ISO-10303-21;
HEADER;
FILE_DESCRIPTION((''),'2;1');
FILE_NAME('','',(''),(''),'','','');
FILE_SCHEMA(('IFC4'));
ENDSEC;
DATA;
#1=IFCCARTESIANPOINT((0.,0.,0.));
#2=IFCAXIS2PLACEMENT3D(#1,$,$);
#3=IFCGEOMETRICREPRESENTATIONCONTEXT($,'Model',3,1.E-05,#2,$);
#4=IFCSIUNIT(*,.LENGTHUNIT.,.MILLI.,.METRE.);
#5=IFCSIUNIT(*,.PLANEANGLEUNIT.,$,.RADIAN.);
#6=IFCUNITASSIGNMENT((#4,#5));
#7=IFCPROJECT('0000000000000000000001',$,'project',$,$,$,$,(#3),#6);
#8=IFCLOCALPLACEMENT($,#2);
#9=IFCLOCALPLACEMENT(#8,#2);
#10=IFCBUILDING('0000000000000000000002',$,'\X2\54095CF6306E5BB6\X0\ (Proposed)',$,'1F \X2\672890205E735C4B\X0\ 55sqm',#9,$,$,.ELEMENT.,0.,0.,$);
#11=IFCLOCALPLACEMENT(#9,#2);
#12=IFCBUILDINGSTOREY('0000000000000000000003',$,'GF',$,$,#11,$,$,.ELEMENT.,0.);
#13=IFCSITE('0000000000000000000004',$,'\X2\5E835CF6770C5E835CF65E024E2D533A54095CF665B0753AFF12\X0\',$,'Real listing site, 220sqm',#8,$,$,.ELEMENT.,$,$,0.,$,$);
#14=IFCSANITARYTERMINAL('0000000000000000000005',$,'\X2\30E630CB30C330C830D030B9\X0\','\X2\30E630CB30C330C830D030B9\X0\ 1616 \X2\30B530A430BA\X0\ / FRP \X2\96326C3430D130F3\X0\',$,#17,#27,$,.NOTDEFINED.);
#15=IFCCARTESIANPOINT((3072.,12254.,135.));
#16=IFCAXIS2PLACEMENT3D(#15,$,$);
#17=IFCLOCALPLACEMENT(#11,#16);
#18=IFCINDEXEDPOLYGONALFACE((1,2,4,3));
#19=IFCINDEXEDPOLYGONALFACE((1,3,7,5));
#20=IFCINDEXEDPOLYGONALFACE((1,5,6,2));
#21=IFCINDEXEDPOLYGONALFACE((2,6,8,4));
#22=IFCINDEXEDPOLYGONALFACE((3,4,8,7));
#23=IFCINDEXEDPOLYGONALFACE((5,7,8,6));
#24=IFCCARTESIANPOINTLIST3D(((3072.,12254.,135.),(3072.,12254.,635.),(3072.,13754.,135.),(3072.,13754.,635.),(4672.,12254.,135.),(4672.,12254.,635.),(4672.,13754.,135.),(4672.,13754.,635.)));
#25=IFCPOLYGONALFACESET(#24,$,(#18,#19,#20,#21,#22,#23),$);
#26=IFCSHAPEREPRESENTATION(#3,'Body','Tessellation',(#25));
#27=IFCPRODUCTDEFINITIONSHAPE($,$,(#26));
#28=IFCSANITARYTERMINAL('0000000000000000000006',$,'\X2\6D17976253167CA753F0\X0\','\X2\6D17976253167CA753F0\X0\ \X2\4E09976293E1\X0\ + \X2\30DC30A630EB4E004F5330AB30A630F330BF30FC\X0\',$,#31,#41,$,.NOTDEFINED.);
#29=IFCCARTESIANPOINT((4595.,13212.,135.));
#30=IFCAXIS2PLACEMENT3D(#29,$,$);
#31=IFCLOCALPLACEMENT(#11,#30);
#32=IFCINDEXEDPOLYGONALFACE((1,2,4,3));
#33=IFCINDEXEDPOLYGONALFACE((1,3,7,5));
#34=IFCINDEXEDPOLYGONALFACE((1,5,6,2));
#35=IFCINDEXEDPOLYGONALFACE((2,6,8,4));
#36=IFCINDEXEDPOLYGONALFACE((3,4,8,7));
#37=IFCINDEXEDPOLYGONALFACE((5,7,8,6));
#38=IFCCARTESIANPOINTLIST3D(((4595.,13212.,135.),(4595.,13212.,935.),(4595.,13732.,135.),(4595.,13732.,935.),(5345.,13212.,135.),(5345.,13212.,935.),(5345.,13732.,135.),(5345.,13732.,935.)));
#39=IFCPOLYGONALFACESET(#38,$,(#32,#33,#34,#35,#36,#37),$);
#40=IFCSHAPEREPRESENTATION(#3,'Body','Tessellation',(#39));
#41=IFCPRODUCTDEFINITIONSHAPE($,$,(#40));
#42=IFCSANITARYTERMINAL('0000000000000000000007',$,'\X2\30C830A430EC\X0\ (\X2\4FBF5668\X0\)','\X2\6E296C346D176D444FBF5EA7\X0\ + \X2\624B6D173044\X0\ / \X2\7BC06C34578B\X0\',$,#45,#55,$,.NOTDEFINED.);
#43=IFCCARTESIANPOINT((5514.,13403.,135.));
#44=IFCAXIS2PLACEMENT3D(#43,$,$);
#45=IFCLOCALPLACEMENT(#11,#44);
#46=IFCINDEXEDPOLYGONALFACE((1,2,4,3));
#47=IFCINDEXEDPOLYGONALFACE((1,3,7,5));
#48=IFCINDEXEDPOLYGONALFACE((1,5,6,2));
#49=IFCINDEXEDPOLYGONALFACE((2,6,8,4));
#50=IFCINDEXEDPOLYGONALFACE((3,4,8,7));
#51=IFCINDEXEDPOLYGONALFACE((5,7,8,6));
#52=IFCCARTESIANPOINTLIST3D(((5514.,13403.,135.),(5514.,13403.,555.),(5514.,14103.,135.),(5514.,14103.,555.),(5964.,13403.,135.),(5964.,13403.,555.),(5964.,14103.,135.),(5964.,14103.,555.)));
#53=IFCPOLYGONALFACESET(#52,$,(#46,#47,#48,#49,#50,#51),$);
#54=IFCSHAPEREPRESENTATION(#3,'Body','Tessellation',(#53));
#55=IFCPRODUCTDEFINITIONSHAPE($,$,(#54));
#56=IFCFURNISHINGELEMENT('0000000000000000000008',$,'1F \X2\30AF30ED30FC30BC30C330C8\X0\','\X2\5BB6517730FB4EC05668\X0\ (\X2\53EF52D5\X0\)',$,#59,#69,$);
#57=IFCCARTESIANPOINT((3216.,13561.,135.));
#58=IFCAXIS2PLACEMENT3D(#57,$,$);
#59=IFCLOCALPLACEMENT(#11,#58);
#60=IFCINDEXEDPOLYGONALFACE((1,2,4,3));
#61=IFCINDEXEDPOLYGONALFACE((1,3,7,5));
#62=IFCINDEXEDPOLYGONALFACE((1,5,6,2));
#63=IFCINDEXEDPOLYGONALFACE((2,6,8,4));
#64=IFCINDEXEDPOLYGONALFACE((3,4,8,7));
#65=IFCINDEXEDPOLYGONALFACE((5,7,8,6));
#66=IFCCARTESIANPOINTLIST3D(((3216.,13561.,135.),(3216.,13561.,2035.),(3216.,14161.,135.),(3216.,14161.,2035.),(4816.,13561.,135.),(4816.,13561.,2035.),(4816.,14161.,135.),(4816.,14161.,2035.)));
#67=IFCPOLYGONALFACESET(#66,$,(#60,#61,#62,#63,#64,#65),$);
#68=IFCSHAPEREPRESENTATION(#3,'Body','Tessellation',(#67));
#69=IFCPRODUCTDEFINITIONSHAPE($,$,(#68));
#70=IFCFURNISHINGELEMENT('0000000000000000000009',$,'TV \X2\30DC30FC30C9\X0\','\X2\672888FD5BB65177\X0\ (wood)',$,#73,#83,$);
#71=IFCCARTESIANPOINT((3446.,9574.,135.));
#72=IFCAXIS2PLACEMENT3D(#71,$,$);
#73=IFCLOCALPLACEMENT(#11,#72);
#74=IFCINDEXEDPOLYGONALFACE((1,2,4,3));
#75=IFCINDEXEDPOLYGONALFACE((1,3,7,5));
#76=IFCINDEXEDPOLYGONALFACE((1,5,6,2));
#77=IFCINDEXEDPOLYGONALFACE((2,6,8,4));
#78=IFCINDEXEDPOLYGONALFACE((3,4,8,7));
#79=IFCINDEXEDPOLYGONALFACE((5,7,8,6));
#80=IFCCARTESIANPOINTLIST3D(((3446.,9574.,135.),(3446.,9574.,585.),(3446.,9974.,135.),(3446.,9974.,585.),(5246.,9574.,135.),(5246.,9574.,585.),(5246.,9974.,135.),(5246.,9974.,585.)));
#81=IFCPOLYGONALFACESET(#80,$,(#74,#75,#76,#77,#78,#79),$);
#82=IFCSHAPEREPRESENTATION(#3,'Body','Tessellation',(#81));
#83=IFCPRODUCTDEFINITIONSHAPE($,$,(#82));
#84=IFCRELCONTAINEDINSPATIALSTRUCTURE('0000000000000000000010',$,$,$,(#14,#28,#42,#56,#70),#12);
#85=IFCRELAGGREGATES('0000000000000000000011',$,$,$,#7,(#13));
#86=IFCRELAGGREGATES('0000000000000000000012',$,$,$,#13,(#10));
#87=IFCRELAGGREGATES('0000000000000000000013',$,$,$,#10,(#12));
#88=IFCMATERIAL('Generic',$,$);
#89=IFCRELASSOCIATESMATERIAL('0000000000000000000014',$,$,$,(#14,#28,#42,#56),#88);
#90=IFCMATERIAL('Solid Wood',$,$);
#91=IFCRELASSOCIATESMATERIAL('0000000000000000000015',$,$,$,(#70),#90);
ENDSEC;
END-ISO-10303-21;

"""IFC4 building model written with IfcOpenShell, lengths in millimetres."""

from ifc_helpers import new_model, si_unit, frame, frame_2d, origin, place, context, project, spatial, rectangle, extrude, material, element, save


model = new_model("IFC4")

# Units and contexts
model_context = context("Model", 3, precision=1e-05, world=origin())
ifc_project = project(units=[si_unit("LENGTHUNIT", "METRE", prefix="MILLI"), si_unit("PLANEANGLEUNIT", "RADIAN")], contexts=[model_context])

# Site, building, storey
site_placement = place(None, origin())
site = spatial("IfcSite", under=ifc_project, at=site_placement, Name="広島県広島市中区吉島新町２", ObjectType="Real listing site, 220sqm", CompositionType="ELEMENT", RefElevation=0.0)
building_placement = place(site_placement, origin())
building = spatial("IfcBuilding", under=site, at=building_placement, Name="吉島の家 (Proposed)", ObjectType="1F 木造平屋 55sqm", CompositionType="ELEMENT", ElevationOfRefHeight=0.0, ElevationOfTerrain=0.0)
storey_placement = place(building_placement, origin())
storey = spatial("IfcBuildingStorey", under=building, at=storey_placement, Name="GF", CompositionType="ELEMENT", Elevation=0.0)

# Shared definitions
ifc_material_1 = material(Name="Solid Wood")

# Shared definitions
ifc_material_2 = material(Name="Generic")

# Sanitary terminals
sanitary_terminal_1_placement = place(storey_placement, frame((3072.0, 12254.0, 135.0)))
element("IfcSanitaryTerminal", 1, at=sanitary_terminal_1_placement, inside=storey, material=ifc_material_2, Name="ユニットバス", Description="ユニットバス 1616 サイズ / FRP 防水パン", PredefinedType="NOTDEFINED", context=model_context, shape_type="SweptSolid", body=[
    extrude(rectangle(XDim=1600.0, YDim=1500.0, at=frame_2d((800.0, 750.0))), frame((3072.0, 12254.0, 135.0)), (0.0, 0.0, 1.0), 500.0),
])
sanitary_terminal_2_placement = place(storey_placement, frame((4595.0, 13212.0, 135.0)))
element("IfcSanitaryTerminal", 2, at=sanitary_terminal_2_placement, inside=storey, material=ifc_material_2, Name="洗面化粧台", Description="洗面化粧台 三面鏡 + ボウル一体カウンター", PredefinedType="NOTDEFINED", context=model_context, shape_type="SweptSolid", body=[
    extrude(rectangle(XDim=750.0, YDim=520.0, at=frame_2d((375.0, 260.0))), frame((4595.0, 13212.0, 135.0)), (0.0, 0.0, 1.0), 800.0),
])
sanitary_terminal_3_placement = place(storey_placement, frame((5514.0, 13403.0, 135.0)))
element("IfcSanitaryTerminal", 3, at=sanitary_terminal_3_placement, inside=storey, material=ifc_material_2, Name="トイレ (便器)", Description="温水洗浄便座 + 手洗い / 節水型", PredefinedType="NOTDEFINED", context=model_context, shape_type="SweptSolid", body=[
    extrude(rectangle(XDim=450.0, YDim=700.0, at=frame_2d((225.0, 350.0))), frame((5514.0, 13403.0, 135.0)), (0.0, 0.0, 1.0), 420.0),
])

# Furnishing elements
furnishing_1_placement = place(storey_placement, frame((3216.0, 13561.0, 135.0)))
element("IfcFurnishingElement", 4, at=furnishing_1_placement, inside=storey, material=ifc_material_2, Name="1F クローゼット", Description="家具・什器 (可動)", context=model_context, shape_type="SweptSolid", body=[
    extrude(rectangle(XDim=1600.0, YDim=600.0, at=frame_2d((800.0, 300.0))), frame((3216.0, 13561.0, 135.0)), (0.0, 0.0, 1.0), 1900.0),
])
furnishing_2_placement = place(storey_placement, frame((3446.0, 9574.0, 135.0)))
element("IfcFurnishingElement", 5, at=furnishing_2_placement, inside=storey, material=ifc_material_1, Name="TV ボード", Description="木製家具 (wood)", context=model_context, shape_type="SweptSolid", body=[
    extrude(rectangle(XDim=1800.0, YDim=400.0, at=frame_2d((900.0, 200.0))), frame((3446.0, 9574.0, 135.0)), (0.0, 0.0, 1.0), 450.0),
])

save(model, "model.ifc")
